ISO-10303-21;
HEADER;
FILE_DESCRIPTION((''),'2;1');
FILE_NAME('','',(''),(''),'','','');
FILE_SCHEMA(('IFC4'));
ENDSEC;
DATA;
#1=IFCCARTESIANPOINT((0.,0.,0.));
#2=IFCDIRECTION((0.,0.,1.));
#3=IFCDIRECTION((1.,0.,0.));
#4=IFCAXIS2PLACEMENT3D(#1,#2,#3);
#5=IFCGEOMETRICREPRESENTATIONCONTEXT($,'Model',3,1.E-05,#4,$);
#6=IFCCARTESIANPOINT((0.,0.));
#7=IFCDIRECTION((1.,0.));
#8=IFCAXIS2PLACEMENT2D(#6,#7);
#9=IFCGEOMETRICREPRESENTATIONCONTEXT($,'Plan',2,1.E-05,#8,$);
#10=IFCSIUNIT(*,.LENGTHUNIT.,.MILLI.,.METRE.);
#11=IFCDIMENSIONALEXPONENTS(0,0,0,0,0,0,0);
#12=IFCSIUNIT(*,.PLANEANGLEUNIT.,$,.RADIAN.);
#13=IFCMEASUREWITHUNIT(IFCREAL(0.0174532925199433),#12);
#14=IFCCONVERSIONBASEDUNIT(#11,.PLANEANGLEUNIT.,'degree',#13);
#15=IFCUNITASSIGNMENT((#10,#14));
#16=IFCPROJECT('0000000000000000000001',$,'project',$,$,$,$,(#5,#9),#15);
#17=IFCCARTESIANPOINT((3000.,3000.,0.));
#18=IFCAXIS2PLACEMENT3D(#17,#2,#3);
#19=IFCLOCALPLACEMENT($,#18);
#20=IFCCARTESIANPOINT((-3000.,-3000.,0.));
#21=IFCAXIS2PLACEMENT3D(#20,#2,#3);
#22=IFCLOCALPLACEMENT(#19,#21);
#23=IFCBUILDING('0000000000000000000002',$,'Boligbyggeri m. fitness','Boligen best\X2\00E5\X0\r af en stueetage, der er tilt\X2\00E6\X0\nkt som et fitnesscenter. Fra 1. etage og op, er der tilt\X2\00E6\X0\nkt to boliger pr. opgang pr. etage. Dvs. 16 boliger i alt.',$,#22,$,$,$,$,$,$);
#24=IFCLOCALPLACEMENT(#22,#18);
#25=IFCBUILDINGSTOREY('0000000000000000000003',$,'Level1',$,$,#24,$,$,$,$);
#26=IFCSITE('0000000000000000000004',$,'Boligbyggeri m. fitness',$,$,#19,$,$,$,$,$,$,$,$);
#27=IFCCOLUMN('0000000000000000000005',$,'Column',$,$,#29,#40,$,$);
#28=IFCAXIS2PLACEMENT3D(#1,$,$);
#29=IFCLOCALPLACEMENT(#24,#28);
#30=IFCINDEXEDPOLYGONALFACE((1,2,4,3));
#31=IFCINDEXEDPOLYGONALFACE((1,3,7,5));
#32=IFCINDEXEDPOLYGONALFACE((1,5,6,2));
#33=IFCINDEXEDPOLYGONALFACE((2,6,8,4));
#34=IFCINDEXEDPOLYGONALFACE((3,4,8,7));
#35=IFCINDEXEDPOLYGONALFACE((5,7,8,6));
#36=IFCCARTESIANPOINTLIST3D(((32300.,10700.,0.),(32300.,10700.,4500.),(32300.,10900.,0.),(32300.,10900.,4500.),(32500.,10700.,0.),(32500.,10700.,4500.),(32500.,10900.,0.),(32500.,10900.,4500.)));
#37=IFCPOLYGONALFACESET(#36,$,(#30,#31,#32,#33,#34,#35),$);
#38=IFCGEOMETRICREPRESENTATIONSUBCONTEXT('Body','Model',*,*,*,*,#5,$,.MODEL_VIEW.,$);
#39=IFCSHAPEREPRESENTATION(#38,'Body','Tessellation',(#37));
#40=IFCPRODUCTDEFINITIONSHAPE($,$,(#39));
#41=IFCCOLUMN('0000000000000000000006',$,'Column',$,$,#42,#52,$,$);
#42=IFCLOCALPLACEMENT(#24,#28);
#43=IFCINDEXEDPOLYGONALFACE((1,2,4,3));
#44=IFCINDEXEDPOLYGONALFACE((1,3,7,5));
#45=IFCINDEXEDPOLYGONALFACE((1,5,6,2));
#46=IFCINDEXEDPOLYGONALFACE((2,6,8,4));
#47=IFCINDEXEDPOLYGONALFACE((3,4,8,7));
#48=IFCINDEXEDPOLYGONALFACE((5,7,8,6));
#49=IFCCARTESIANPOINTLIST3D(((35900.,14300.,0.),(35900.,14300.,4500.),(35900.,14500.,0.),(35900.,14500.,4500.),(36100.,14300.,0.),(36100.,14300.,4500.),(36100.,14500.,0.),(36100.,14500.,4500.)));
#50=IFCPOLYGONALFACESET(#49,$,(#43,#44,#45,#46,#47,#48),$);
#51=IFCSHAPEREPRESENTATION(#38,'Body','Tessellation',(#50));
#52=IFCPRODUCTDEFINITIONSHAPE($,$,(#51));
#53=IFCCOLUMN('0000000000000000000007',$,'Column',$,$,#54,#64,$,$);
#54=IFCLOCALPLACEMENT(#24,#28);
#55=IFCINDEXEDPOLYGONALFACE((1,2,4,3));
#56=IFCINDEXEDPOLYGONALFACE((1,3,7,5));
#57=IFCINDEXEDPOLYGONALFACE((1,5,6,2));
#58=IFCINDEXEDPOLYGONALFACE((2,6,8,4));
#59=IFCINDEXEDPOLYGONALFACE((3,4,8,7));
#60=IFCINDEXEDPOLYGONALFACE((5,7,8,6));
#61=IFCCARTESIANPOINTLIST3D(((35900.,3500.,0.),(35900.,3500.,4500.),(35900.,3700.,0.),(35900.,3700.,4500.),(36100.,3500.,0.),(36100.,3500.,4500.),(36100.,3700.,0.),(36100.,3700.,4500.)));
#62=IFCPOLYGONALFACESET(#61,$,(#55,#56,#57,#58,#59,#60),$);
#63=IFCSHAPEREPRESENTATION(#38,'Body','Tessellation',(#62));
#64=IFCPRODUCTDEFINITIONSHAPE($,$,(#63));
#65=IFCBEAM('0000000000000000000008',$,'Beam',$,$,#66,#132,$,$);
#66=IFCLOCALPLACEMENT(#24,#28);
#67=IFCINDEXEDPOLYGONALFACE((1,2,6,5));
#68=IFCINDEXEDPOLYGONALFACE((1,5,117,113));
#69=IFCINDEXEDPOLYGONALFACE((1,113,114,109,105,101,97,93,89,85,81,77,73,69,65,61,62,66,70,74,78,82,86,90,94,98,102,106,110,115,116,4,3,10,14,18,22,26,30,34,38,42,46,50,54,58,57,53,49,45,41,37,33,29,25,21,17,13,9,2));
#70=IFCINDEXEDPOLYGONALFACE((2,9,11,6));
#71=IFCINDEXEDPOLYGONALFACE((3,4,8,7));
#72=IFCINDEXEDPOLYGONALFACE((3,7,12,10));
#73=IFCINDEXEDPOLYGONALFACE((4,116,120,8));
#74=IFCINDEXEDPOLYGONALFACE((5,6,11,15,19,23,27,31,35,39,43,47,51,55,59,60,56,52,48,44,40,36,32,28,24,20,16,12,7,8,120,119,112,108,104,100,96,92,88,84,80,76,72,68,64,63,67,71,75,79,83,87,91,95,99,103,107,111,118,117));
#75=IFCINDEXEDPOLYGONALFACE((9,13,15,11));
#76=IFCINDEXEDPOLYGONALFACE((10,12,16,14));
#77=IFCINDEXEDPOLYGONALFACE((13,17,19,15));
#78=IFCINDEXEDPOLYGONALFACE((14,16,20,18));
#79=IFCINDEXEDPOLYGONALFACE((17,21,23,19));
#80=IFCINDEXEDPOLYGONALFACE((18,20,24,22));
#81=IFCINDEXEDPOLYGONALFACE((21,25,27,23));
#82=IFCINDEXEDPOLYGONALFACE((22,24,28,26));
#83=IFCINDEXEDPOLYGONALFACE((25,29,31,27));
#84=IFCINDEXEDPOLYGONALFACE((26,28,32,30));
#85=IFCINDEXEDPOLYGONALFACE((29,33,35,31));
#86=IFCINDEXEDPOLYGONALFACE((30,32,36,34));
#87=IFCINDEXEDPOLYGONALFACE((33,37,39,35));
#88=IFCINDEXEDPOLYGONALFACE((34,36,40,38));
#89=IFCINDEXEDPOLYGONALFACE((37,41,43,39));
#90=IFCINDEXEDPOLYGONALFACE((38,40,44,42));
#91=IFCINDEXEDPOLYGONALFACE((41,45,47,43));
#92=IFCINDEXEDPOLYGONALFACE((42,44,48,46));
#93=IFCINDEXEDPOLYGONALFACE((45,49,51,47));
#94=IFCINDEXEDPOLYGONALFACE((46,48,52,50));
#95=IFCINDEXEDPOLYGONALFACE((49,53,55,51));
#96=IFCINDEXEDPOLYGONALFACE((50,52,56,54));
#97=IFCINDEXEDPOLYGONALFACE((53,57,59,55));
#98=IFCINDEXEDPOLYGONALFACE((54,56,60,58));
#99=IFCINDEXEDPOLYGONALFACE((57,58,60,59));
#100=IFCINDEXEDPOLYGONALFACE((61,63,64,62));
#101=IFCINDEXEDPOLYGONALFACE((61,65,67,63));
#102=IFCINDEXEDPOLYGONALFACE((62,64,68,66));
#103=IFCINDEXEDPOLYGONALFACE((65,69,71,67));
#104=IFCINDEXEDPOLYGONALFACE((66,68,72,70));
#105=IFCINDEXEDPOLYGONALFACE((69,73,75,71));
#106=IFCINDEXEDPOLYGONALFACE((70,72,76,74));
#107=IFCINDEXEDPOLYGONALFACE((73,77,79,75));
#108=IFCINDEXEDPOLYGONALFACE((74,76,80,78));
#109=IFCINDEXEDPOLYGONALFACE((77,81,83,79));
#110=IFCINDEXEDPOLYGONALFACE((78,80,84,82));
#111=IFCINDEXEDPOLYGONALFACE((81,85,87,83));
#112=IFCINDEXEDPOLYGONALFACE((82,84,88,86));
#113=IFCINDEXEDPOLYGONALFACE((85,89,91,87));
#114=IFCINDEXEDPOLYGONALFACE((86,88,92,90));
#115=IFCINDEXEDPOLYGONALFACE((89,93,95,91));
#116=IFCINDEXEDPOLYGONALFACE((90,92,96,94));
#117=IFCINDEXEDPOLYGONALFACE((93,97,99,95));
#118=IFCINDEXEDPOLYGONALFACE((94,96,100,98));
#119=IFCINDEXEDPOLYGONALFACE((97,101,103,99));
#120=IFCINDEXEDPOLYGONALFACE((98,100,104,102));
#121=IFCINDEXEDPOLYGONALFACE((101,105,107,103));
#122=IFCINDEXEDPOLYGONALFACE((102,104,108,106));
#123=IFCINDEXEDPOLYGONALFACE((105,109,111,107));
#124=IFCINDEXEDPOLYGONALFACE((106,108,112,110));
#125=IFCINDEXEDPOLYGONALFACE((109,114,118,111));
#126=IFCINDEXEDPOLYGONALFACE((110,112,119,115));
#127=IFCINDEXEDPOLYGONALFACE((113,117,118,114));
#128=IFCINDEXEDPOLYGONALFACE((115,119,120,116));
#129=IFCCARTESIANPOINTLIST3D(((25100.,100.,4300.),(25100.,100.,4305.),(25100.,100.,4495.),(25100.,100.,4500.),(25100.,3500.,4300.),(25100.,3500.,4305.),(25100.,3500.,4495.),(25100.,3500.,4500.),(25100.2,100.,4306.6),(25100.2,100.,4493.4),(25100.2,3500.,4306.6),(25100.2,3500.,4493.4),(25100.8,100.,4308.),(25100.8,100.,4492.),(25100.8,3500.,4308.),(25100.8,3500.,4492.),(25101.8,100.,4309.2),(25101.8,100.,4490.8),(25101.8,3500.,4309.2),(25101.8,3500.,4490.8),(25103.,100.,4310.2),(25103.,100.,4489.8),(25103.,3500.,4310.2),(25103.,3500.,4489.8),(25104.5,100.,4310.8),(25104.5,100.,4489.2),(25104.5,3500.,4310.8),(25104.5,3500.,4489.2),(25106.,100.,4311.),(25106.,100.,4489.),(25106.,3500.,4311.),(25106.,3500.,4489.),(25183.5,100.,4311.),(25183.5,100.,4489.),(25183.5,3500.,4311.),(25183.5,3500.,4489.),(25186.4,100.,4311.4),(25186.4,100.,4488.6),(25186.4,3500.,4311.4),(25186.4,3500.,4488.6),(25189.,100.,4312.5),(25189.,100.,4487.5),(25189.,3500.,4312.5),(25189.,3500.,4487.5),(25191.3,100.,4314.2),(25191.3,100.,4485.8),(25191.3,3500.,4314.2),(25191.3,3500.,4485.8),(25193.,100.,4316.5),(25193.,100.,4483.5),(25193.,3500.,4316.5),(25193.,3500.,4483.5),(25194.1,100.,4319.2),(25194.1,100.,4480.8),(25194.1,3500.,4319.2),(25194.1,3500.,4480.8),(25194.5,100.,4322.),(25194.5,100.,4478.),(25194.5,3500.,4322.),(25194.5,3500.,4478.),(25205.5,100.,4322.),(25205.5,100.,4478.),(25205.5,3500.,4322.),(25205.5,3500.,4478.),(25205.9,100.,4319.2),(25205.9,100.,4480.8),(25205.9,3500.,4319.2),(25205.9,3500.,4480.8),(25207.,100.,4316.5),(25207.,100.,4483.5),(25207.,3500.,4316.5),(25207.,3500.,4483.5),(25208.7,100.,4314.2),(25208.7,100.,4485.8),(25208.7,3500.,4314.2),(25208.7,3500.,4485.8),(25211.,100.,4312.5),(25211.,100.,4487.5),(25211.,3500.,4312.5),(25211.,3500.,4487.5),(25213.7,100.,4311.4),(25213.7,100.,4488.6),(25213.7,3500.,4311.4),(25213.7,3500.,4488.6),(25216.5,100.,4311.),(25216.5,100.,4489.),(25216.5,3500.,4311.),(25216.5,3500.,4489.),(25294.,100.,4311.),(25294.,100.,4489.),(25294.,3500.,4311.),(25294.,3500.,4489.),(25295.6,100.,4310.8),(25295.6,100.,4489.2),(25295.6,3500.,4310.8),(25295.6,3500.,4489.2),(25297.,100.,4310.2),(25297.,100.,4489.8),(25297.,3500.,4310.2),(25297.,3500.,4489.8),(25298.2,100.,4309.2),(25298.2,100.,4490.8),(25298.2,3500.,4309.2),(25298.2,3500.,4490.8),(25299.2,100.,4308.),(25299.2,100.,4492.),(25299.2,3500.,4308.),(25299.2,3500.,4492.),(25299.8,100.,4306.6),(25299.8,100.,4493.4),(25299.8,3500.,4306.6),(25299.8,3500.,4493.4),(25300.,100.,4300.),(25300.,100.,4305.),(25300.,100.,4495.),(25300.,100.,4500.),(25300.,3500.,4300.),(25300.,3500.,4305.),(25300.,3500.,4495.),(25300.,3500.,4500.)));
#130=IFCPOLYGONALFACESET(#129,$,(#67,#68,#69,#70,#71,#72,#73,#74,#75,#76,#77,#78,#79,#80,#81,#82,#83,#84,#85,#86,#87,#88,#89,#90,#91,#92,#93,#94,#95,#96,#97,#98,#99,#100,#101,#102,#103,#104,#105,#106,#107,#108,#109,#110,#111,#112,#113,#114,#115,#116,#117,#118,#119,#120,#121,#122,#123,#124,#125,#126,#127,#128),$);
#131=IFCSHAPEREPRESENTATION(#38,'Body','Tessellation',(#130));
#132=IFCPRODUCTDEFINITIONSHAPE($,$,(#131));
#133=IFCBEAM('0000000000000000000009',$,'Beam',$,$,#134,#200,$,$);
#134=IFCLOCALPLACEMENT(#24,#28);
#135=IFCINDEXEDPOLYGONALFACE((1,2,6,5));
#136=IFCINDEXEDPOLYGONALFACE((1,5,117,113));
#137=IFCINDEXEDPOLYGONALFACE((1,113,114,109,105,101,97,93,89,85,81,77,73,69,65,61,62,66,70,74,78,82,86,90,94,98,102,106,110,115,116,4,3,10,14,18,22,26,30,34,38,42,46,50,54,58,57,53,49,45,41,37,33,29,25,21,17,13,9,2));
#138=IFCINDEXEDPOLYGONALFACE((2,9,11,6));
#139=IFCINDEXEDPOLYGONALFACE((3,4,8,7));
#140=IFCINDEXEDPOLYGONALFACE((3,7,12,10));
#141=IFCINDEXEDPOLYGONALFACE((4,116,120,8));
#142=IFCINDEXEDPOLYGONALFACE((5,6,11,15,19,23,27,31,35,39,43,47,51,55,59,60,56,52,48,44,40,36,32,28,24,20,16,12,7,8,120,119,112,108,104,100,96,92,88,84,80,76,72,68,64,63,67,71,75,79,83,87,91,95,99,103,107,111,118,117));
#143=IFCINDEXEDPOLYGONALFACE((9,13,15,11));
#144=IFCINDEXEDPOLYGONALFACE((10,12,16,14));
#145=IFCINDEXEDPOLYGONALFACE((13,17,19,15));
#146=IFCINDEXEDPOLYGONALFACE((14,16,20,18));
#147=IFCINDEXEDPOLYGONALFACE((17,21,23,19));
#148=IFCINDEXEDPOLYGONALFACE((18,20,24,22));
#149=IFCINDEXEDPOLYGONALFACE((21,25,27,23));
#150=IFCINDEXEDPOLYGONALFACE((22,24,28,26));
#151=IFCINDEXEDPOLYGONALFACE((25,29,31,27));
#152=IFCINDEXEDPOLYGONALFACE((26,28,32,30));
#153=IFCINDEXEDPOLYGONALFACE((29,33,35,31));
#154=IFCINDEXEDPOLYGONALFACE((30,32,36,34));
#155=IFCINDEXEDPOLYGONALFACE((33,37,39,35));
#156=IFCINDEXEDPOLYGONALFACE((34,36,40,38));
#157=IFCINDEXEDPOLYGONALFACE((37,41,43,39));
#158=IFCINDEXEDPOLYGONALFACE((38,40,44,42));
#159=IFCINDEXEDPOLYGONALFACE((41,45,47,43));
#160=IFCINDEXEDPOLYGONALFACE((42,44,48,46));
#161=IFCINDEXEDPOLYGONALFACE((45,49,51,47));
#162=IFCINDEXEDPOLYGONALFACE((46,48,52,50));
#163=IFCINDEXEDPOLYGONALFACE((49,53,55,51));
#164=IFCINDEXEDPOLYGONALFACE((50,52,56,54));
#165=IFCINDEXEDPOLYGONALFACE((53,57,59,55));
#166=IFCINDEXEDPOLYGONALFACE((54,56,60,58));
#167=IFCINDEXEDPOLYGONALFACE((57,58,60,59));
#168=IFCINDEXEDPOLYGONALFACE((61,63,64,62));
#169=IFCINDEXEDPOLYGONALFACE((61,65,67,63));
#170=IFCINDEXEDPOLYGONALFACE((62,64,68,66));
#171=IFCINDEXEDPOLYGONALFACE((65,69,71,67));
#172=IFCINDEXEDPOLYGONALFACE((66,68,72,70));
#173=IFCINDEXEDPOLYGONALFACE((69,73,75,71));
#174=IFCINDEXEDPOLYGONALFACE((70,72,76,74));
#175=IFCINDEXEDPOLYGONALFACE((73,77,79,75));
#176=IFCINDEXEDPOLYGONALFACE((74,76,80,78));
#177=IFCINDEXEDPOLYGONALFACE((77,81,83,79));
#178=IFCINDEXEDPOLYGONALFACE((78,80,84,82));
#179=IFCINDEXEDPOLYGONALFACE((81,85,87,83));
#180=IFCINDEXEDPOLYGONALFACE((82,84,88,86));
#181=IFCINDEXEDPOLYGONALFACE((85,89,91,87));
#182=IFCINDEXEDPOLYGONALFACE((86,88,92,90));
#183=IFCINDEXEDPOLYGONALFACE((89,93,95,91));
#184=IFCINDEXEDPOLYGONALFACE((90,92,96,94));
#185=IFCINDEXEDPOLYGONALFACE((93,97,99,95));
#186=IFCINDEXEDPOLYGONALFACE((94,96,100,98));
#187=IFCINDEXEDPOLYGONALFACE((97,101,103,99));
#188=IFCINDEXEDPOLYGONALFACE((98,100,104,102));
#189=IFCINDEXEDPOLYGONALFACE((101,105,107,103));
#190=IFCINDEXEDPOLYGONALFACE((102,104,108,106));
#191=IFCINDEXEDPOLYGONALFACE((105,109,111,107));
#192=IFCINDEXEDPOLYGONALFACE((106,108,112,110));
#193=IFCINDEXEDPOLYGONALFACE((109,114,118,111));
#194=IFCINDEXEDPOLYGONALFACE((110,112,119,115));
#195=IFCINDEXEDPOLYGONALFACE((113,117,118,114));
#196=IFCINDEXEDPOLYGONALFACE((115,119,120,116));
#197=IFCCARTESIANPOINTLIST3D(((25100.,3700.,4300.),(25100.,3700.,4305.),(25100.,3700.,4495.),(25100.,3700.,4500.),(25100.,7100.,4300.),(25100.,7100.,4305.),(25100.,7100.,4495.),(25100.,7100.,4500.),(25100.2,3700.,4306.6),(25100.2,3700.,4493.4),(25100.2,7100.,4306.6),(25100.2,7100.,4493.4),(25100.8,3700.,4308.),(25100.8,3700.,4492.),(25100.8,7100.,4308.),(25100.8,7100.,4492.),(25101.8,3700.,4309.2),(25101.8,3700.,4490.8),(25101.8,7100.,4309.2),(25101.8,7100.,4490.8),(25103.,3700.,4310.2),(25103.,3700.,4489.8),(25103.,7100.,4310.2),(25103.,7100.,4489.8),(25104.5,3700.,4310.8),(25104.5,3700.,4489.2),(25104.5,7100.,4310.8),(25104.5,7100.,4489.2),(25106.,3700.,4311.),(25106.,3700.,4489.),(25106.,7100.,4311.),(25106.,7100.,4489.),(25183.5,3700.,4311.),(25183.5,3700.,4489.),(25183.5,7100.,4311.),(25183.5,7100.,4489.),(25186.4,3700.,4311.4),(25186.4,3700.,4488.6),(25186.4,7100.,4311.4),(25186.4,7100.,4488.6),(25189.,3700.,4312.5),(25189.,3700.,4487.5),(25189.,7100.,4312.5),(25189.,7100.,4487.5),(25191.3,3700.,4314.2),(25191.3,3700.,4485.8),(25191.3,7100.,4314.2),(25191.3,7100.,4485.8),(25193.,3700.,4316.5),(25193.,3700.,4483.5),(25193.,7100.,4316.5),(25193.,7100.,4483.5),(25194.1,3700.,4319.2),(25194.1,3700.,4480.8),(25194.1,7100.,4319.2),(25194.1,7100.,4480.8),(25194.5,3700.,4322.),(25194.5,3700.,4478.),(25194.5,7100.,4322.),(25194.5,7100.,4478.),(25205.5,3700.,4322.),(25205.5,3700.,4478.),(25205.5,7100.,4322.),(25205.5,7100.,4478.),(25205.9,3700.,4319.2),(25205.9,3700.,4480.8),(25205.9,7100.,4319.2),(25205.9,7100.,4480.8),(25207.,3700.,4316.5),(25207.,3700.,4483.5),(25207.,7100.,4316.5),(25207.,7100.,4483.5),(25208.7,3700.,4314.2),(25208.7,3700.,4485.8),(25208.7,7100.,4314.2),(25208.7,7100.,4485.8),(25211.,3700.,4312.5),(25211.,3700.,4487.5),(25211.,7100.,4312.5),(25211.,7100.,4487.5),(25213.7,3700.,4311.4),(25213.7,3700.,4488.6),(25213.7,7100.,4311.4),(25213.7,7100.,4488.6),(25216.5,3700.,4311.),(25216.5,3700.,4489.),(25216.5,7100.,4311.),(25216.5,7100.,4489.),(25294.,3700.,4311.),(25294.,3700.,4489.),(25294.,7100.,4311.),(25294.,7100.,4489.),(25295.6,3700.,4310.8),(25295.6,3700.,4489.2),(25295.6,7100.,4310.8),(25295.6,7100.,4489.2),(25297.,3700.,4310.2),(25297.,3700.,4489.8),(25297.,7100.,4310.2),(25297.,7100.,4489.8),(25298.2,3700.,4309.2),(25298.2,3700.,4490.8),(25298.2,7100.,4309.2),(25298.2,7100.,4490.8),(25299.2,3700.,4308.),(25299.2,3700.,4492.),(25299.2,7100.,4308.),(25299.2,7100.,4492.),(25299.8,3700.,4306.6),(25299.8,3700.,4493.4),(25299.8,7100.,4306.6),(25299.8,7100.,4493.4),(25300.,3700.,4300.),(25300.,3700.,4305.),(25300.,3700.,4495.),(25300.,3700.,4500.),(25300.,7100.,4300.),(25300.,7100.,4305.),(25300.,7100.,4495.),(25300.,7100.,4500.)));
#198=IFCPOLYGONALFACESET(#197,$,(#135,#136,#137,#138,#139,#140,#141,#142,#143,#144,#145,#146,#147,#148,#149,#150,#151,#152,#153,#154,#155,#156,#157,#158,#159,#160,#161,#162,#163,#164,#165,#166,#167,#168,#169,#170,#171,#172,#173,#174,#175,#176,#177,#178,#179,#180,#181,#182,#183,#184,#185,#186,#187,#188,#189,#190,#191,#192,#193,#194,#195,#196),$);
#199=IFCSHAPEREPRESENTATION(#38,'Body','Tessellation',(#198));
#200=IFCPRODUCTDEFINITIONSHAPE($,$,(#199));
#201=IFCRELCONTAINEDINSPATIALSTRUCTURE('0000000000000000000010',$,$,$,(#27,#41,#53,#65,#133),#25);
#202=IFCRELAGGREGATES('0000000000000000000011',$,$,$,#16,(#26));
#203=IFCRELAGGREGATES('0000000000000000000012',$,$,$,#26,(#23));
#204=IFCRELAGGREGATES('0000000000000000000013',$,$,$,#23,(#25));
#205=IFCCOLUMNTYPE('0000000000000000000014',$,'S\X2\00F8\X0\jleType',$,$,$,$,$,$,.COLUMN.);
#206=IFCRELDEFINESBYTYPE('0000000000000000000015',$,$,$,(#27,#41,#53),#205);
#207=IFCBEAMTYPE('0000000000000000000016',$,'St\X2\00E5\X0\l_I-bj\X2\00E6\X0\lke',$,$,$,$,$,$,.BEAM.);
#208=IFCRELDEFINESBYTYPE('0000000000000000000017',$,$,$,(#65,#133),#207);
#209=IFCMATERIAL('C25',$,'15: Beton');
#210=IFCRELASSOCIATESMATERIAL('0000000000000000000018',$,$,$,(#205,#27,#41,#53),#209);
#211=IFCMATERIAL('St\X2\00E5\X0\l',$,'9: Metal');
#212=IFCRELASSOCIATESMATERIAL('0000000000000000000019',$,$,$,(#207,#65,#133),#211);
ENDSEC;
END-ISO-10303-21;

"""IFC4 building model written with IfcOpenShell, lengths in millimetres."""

from ifc_helpers import new_model, entity, si_unit, converted_unit, frame, origin_with_axes, origin_2d_with_axis, place, context, subcontext, project, spatial, rectangle, i_section, extrude, material, material_profile, profile_set, profile_usage, type_object, element, save


model = new_model("IFC4")

# Units and contexts
model_context = context("Model", 3, precision=1e-05, world=origin_with_axes())
plan_context = context("Plan", 2, precision=1e-05, world=origin_2d_with_axis())
body_context = subcontext(model_context, "Body", "Model", "MODEL_VIEW")
ifc_project = project(units=[si_unit("LENGTHUNIT", "METRE", prefix="MILLI"), converted_unit("PLANEANGLEUNIT", "degree", entity("IfcReal", 0.0174532925199433), si_unit("PLANEANGLEUNIT", "RADIAN"), dimensions=[0, 0, 0, 0, 0, 0, 0])], contexts=[model_context, plan_context])

# Site, building, storey
site_placement = place(None, frame((3000.0, 3000.0, 0.0), z_axis=(0.0, 0.0, 1.0), x_axis=(1.0, 0.0, 0.0)))
site = spatial("IfcSite", under=ifc_project, at=site_placement, Name="Boligbyggeri m. fitness")
building_placement = place(site_placement, frame((-3000.0, -3000.0, 0.0), z_axis=(0.0, 0.0, 1.0), x_axis=(1.0, 0.0, 0.0)))
building = spatial("IfcBuilding", under=site, at=building_placement, Name="Boligbyggeri m. fitness", Description="Boligen består af en stueetage, der er tiltænkt som et fitnesscenter. Fra 1. etage og op, er der tiltænkt to boliger pr. opgang pr. etage. Dvs. 16 boliger i alt.")
storey_placement = place(building_placement, frame((3000.0, 3000.0, 0.0), z_axis=(0.0, 0.0, 1.0), x_axis=(1.0, 0.0, 0.0)))
storey = spatial("IfcBuildingStorey", under=building, at=storey_placement, Name="Level1")

# Shared definitions
ifc_material_1 = material(Name="C25", Category="15: Beton")

# Columns
ifc_material_profile_1 = material_profile(ifc_material_1, rectangle(XDim=200.0, YDim=200.0), Name="SøjleBeton", Category="15: Beton")
ifc_profile_set_1 = profile_set([ifc_material_profile_1], Name="200x200")
column_type = type_object("IfcColumnType", Name="SøjleType", PredefinedType="COLUMN", material=ifc_profile_set_1)
ifc_profile_usage_1 = profile_usage(ifc_profile_set_1, cardinal=5)
column_1_placement = place(storey_placement, frame((32400.0, 10800.0, 0.0), z_axis=(0.0, 0.0, 1.0), x_axis=(1.0, 0.0, 0.0)))
element("IfcColumn", 1, at=column_1_placement, inside=storey, type_object=column_type, material=ifc_profile_usage_1, Name="Column", context=body_context, shape_type="SweptSolid", body=[
    extrude(rectangle(XDim=200.0, YDim=200.0), origin_with_axes(), (0.0, 0.0, 1.0), 4500.0),
])
ifc_profile_usage_2 = profile_usage(ifc_profile_set_1, cardinal=5)
column_2_placement = place(storey_placement, frame((36000.0, 14400.0, 0.0), z_axis=(0.0, 0.0, 1.0), x_axis=(1.0, 0.0, 0.0)))
element("IfcColumn", 2, at=column_2_placement, inside=storey, type_object=column_type, material=ifc_profile_usage_2, Name="Column", context=body_context, shape_type="SweptSolid", body=[
    extrude(rectangle(XDim=200.0, YDim=200.0), origin_with_axes(), (0.0, 0.0, 1.0), 4500.0),
])
ifc_profile_usage_3 = profile_usage(ifc_profile_set_1, cardinal=5)
column_3_placement = place(storey_placement, frame((36000.0, 3600.0, 0.0), z_axis=(0.0, 0.0, 1.0), x_axis=(1.0, 0.0, 0.0)))
element("IfcColumn", 3, at=column_3_placement, inside=storey, type_object=column_type, material=ifc_profile_usage_3, Name="Column", context=body_context, shape_type="SweptSolid", body=[
    extrude(rectangle(XDim=200.0, YDim=200.0), origin_with_axes(), (0.0, 0.0, 1.0), 4500.0),
])

# Beams
ifc_material_2 = material(Name="Stål", Category="9: Metal")
ifc_material_profile_2 = material_profile(ifc_material_2, i_section(OverallWidth=200.0, OverallDepth=200.0, WebThickness=11.0, FlangeThickness=11.0, FilletRadius=11.0, FlangeEdgeRadius=6.0), Name="Stål", Category="9: Metal")
ifc_profile_set_2 = profile_set([ifc_material_profile_2], Name="NY_I-Profil")
ifc_profile_usage_4 = profile_usage(ifc_profile_set_2, cardinal=9)
beam_type = type_object("IfcBeamType", Name="Stål_I-bjælke", PredefinedType="BEAM", material=ifc_profile_set_2)
beam_1_placement = place(storey_placement, frame((25300.0, 100.0, 4500.0), z_axis=(0.0, 1.0, 0.0), x_axis=(-1.0, 0.0, 0.0)))
element("IfcBeam", 4, at=beam_1_placement, inside=storey, type_object=beam_type, material=ifc_profile_usage_4, Name="Beam", context=body_context, shape_type="SweptSolid", body=[
    extrude(i_section(OverallWidth=200.0, OverallDepth=200.0, WebThickness=11.0, FlangeThickness=11.0, FilletRadius=11.0, FlangeEdgeRadius=6.0), frame((100.0, -100.0, 0.0), z_axis=(0.0, 0.0, 1.0), x_axis=(1.0, 0.0, 0.0)), (0.0, 0.0, 1.0), 3400.0),
])
ifc_profile_usage_5 = profile_usage(ifc_profile_set_2, cardinal=9)
beam_2_placement = place(storey_placement, frame((25300.0, 3700.0, 4500.0), z_axis=(0.0, 1.0, 0.0), x_axis=(-1.0, 0.0, 0.0)))
element("IfcBeam", 5, at=beam_2_placement, inside=storey, type_object=beam_type, material=ifc_profile_usage_5, Name="Beam", context=body_context, shape_type="SweptSolid", body=[
    extrude(i_section(OverallWidth=200.0, OverallDepth=200.0, WebThickness=11.0, FlangeThickness=11.0, FilletRadius=11.0, FlangeEdgeRadius=6.0), frame((100.0, -100.0, 0.0), z_axis=(0.0, 0.0, 1.0), x_axis=(1.0, 0.0, 0.0)), (0.0, 0.0, 1.0), 3400.0),
])

save(model, "model.ifc")
